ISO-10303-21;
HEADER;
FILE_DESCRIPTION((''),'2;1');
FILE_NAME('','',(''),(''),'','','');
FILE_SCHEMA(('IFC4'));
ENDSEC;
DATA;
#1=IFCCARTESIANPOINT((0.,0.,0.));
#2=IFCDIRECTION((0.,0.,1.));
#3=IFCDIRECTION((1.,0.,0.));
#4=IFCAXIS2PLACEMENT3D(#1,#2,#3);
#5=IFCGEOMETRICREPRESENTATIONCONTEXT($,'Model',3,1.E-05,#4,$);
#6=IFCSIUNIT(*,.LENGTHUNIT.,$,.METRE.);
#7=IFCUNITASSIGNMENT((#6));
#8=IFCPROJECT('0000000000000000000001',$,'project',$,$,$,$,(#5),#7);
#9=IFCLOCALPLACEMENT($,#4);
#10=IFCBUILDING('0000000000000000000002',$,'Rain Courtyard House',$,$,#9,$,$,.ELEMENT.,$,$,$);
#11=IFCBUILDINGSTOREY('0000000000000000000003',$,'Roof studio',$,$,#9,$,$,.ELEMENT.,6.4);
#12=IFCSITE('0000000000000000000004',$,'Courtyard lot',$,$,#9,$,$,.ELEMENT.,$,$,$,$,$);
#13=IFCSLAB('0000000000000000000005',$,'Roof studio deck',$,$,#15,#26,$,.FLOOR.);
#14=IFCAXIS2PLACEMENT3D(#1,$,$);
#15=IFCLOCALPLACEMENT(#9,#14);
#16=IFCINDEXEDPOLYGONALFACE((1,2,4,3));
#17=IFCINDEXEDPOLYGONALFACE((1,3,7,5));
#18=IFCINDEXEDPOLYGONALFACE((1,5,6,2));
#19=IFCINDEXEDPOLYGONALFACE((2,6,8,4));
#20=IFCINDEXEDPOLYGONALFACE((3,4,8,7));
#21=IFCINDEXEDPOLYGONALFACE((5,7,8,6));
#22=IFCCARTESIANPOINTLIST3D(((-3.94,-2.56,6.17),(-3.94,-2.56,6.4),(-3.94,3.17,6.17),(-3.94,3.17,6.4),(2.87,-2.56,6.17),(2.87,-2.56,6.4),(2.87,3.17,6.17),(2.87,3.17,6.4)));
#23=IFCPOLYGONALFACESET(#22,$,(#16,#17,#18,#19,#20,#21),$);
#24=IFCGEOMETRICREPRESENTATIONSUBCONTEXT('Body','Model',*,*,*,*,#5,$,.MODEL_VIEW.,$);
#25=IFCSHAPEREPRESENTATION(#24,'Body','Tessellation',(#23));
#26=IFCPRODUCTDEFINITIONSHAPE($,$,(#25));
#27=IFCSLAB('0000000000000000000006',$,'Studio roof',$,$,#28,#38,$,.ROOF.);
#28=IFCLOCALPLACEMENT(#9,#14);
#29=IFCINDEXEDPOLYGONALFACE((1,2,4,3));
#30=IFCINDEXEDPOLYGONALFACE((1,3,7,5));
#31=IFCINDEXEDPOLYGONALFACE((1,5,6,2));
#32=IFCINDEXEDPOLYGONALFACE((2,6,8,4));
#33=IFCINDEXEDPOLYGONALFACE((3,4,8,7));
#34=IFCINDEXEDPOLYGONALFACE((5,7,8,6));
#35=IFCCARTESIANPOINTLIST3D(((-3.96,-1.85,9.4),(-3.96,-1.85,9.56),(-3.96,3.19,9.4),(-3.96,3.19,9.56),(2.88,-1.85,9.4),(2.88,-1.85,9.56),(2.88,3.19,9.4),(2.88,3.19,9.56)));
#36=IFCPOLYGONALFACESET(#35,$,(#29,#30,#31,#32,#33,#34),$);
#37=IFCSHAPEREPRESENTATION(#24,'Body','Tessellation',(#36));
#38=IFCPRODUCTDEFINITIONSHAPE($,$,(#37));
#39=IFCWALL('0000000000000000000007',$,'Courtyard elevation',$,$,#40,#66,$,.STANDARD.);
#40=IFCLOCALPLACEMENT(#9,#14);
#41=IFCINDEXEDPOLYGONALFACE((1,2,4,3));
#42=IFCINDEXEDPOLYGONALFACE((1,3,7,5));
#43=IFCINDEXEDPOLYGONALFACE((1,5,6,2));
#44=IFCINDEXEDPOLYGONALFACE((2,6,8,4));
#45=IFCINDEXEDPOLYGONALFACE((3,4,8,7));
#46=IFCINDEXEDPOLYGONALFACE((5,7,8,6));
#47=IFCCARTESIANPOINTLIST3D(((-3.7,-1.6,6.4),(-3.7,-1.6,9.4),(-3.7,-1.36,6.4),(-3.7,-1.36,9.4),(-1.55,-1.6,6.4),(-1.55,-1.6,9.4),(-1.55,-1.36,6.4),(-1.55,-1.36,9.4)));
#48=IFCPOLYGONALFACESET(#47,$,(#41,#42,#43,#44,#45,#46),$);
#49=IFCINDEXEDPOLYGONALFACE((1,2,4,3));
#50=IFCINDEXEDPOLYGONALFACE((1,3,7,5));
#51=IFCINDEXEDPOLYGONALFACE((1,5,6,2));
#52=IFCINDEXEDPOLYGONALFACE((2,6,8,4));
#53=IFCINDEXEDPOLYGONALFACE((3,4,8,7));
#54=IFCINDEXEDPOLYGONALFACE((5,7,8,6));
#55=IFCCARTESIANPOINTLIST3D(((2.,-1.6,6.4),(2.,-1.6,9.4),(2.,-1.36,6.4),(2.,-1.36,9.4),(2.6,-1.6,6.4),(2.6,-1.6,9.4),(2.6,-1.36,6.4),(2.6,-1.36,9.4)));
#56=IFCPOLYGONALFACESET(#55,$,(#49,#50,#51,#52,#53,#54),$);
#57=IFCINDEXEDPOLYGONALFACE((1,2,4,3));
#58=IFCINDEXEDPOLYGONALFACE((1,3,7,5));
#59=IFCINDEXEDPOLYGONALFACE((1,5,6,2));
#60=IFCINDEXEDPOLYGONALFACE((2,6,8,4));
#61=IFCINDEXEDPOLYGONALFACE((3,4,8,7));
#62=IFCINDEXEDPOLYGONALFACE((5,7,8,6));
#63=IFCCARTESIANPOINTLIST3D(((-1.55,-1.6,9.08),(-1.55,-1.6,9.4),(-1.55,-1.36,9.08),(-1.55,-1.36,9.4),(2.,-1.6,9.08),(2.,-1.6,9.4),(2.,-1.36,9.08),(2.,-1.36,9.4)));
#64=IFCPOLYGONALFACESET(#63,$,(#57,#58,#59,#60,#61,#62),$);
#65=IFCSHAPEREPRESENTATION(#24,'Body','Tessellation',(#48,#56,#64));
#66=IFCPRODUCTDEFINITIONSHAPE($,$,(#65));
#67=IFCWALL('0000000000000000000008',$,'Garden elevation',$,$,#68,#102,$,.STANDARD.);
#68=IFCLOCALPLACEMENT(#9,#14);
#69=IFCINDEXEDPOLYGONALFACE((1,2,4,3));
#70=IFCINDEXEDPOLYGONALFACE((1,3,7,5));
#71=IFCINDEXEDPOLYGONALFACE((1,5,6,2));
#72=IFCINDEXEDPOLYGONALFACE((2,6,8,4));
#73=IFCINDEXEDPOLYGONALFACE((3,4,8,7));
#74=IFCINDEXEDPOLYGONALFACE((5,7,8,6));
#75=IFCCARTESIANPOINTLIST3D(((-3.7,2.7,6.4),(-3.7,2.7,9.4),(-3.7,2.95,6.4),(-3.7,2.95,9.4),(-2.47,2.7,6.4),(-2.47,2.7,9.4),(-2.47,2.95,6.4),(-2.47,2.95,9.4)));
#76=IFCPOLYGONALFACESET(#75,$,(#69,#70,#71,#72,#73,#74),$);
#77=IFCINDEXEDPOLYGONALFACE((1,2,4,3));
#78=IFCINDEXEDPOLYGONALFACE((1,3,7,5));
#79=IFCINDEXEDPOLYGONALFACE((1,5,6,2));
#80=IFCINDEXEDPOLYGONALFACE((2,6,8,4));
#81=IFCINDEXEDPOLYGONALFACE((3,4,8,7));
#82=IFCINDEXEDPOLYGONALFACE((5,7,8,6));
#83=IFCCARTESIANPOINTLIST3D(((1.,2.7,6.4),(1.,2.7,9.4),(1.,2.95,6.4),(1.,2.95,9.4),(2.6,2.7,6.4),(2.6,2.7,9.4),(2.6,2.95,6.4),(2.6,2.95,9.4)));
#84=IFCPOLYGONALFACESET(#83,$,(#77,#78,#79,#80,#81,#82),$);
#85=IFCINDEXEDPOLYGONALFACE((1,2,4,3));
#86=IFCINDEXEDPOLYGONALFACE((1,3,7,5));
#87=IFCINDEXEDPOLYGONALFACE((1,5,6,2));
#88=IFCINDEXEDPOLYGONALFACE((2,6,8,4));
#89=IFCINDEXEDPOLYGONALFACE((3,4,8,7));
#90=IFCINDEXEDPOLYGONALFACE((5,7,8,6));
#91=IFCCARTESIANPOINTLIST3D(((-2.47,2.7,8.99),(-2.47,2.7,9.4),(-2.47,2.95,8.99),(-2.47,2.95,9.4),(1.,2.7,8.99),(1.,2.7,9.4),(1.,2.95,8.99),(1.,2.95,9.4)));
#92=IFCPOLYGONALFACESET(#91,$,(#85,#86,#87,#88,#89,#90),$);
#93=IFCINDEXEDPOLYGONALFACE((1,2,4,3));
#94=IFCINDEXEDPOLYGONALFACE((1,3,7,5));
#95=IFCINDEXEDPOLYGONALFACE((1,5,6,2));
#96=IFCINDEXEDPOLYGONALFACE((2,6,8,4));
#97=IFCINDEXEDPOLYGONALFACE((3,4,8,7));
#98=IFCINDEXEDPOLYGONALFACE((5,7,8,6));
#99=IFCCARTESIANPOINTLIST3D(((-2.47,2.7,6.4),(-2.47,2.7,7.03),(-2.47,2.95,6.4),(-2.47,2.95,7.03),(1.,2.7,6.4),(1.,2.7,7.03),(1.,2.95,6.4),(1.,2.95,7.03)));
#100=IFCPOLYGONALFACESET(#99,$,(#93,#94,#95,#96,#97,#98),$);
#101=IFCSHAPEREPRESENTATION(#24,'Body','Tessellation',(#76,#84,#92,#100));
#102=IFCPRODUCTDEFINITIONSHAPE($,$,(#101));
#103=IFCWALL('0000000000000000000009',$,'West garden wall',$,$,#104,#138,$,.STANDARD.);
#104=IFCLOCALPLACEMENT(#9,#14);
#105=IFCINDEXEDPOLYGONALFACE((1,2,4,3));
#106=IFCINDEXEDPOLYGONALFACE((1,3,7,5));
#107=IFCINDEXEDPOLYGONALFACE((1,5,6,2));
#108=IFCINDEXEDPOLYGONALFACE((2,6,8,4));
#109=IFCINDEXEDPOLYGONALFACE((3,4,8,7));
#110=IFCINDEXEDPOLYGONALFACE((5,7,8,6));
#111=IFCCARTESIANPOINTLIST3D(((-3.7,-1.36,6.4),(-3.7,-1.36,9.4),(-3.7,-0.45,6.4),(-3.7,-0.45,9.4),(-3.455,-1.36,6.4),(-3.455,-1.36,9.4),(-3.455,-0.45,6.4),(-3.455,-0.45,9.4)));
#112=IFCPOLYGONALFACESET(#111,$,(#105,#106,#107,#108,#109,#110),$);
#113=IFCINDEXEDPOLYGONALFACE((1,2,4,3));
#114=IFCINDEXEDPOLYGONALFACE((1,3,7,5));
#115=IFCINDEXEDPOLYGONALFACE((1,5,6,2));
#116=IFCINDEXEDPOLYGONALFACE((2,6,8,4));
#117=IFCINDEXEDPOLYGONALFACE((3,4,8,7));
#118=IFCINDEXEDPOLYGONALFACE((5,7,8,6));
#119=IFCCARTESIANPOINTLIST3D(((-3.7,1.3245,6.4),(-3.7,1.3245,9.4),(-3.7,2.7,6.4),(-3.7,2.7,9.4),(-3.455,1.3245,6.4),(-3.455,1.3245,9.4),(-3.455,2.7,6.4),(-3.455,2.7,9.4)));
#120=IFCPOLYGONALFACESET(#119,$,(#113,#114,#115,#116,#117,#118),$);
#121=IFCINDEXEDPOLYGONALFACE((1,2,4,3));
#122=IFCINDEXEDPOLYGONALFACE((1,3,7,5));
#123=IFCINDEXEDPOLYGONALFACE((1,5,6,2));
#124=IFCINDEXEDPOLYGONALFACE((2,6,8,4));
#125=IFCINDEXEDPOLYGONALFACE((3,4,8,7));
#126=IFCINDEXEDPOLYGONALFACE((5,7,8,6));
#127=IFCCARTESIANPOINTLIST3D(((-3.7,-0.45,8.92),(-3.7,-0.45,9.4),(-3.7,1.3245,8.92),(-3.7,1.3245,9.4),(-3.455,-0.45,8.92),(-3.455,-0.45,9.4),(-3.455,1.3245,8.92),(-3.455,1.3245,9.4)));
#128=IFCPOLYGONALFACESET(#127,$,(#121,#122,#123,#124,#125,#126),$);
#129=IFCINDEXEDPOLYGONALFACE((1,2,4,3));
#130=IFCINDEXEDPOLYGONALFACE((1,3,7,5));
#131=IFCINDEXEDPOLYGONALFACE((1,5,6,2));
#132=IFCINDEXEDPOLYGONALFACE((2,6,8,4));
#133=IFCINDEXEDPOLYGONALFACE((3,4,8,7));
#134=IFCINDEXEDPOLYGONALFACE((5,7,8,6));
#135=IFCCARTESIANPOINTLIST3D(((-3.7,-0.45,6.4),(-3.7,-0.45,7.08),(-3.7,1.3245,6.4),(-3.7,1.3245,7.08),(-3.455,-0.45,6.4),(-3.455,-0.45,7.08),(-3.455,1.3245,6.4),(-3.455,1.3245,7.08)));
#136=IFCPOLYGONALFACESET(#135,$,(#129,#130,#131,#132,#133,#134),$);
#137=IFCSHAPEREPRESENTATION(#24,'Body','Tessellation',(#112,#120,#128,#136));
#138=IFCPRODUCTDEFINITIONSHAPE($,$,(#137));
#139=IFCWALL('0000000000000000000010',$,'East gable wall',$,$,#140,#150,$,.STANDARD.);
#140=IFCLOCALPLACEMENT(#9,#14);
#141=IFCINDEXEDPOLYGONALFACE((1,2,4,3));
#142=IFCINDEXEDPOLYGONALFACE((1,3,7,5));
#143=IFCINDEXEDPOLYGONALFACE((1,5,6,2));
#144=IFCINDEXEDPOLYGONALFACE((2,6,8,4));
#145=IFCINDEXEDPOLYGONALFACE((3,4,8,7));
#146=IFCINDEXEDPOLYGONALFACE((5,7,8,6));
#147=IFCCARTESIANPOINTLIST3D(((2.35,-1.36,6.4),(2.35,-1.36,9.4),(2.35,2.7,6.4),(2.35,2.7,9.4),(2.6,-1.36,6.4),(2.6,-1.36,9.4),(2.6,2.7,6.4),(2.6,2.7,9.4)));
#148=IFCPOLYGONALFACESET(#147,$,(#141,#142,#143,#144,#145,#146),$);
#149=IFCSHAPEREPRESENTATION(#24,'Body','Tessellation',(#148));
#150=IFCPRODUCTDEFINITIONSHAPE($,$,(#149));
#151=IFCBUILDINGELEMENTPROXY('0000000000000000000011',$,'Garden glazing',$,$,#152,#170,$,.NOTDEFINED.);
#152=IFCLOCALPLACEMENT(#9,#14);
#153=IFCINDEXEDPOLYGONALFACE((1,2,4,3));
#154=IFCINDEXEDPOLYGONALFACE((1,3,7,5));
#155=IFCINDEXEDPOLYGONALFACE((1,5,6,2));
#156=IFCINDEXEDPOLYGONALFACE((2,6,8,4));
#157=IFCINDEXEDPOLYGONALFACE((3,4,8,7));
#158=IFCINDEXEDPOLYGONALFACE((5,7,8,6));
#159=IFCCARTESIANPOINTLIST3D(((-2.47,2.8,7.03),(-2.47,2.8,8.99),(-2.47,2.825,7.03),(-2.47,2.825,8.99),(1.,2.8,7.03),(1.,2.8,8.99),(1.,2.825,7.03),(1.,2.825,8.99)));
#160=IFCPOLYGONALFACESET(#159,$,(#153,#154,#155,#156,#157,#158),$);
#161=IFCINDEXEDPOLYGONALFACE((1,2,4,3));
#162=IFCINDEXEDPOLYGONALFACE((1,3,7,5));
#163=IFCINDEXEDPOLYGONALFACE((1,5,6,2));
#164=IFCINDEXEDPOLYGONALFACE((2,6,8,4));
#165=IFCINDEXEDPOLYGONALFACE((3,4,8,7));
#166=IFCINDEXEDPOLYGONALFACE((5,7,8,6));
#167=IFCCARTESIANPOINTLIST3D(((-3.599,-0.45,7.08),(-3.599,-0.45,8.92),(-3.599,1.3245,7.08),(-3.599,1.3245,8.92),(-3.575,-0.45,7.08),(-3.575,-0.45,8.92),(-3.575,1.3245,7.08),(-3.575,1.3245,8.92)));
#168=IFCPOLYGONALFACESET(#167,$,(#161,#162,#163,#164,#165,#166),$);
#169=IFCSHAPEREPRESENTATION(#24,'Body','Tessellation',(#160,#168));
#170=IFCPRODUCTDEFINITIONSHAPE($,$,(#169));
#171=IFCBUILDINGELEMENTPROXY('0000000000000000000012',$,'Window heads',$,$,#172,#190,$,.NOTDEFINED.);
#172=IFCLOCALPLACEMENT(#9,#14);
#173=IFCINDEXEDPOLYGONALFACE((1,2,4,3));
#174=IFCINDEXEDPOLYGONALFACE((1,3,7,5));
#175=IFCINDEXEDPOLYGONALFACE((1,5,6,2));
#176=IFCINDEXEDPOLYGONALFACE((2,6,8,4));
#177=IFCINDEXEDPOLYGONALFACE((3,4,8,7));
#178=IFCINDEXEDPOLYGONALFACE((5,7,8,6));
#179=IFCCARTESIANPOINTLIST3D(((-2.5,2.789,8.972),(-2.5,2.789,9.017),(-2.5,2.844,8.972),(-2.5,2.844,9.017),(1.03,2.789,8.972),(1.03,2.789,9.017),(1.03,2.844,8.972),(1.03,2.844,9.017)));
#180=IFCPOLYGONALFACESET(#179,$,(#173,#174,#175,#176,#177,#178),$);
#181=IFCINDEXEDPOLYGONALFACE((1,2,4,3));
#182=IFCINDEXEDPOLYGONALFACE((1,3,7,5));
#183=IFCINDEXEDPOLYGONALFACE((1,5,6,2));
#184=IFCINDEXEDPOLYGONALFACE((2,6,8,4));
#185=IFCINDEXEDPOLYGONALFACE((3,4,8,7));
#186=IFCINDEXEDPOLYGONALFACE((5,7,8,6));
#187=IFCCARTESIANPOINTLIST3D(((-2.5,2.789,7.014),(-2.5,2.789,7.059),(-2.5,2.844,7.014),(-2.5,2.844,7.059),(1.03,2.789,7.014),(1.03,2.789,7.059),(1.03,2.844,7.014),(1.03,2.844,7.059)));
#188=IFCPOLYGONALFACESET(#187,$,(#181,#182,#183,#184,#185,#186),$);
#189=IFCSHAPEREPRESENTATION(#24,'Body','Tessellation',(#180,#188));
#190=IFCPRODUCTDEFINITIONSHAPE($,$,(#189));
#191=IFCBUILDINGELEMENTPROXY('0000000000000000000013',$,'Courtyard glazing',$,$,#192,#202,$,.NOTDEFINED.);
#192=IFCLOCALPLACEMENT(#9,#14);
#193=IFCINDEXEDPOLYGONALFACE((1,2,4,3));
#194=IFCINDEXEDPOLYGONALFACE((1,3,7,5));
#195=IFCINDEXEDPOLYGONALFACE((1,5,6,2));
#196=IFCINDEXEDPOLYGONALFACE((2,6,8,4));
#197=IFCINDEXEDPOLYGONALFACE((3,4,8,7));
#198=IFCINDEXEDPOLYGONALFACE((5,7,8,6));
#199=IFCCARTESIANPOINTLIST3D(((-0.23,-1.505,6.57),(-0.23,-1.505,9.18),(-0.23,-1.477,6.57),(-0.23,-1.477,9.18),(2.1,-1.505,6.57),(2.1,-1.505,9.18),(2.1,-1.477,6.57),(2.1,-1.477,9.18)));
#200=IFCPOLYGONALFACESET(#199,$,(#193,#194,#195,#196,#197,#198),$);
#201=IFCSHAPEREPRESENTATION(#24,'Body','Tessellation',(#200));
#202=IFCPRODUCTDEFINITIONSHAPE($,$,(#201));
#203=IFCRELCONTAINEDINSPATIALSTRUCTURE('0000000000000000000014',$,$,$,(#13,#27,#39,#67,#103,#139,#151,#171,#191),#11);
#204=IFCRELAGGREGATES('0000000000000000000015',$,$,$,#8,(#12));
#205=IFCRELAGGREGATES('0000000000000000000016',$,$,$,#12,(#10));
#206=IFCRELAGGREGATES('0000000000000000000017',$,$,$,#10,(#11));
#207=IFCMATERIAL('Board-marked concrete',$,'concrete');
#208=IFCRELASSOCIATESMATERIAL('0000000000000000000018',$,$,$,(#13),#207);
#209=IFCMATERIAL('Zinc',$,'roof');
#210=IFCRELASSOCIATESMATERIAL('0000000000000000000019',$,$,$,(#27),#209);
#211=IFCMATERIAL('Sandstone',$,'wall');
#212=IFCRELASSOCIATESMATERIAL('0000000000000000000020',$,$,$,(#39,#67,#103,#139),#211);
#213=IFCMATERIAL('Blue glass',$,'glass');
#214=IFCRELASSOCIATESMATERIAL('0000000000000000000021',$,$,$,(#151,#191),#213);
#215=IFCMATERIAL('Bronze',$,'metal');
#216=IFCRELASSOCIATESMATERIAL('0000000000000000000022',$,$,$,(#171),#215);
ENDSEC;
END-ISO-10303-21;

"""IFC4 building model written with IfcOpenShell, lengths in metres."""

from ifc_helpers import new_model, si_unit, frame, origin_with_axes, origin_2d, place, context, subcontext, project, spatial, rectangle, extrude, material, element, save


model = new_model("IFC4")

# Units and contexts
model_context = context("Model", 3, precision=1e-05, world=origin_with_axes())
body_context = subcontext(model_context, "Body", "Model", "MODEL_VIEW")
ifc_project = project(units=[si_unit("LENGTHUNIT", "METRE")], contexts=[model_context])

# Site, building, storey
placement = place(None, origin_with_axes())
site = spatial("IfcSite", under=ifc_project, at=placement, Name="Courtyard lot", CompositionType="ELEMENT")
building = spatial("IfcBuilding", under=site, at=placement, Name="Rain Courtyard House", CompositionType="ELEMENT")
storey = spatial("IfcBuildingStorey", under=building, at=placement, Name="Roof studio", CompositionType="ELEMENT", Elevation=6.4)

# Slabs
ifc_material_1 = material(Name="Board-marked concrete", Category="concrete")
element("IfcSlab", 1, at=placement, inside=storey, material=ifc_material_1, Name="Roof studio deck", PredefinedType="FLOOR", context=body_context, shape_type="SweptSolid", body=[
    extrude(rectangle(XDim=6.81, YDim=5.73, at=origin_2d()), frame((-0.535, 0.305, 6.17), z_axis=(0.0, 0.0, 1.0), x_axis=(1.0, 0.0, 0.0)), (0.0, 0.0, 1.0), 0.23),
])
ifc_material_2 = material(Name="Zinc", Category="roof")
element("IfcSlab", 2, at=placement, inside=storey, material=ifc_material_2, Name="Studio roof", PredefinedType="ROOF", context=body_context, shape_type="SweptSolid", body=[
    extrude(rectangle(XDim=6.84, YDim=5.04, at=origin_2d()), frame((-0.54, 0.67, 9.4), z_axis=(0.0, 0.0, 1.0), x_axis=(1.0, 0.0, 0.0)), (0.0, 0.0, 1.0), 0.16),
])

# Walls
ifc_material_3 = material(Name="Sandstone", Category="wall")
element("IfcWall", 3, at=placement, inside=storey, material=ifc_material_3, Name="Courtyard elevation", PredefinedType="STANDARD", context=body_context, shape_type="SweptSolid", body=[
    extrude(rectangle(XDim=2.15, YDim=0.24, at=origin_2d()), frame((-2.625, -1.48, 6.4), z_axis=(0.0, 0.0, 1.0), x_axis=(1.0, 0.0, 0.0)), (0.0, 0.0, 1.0), 3.0),
    extrude(rectangle(XDim=0.6, YDim=0.24, at=origin_2d()), frame((2.3, -1.48, 6.4), z_axis=(0.0, 0.0, 1.0), x_axis=(1.0, 0.0, 0.0)), (0.0, 0.0, 1.0), 3.0),
    extrude(rectangle(XDim=3.55, YDim=0.24, at=origin_2d()), frame((0.225, -1.48, 9.08), z_axis=(0.0, 0.0, 1.0), x_axis=(1.0, 0.0, 0.0)), (0.0, 0.0, 1.0), 0.32),
])
element("IfcWall", 4, at=placement, inside=storey, material=ifc_material_3, Name="Garden elevation", PredefinedType="STANDARD", context=body_context, shape_type="SweptSolid", body=[
    extrude(rectangle(XDim=1.23, YDim=0.25, at=origin_2d()), frame((-3.085, 2.825, 6.4), z_axis=(0.0, 0.0, 1.0), x_axis=(1.0, 0.0, 0.0)), (0.0, 0.0, 1.0), 3.0),
    extrude(rectangle(XDim=1.6, YDim=0.25, at=origin_2d()), frame((1.8, 2.825, 6.4), z_axis=(0.0, 0.0, 1.0), x_axis=(1.0, 0.0, 0.0)), (0.0, 0.0, 1.0), 3.0),
    extrude(rectangle(XDim=3.47, YDim=0.25, at=origin_2d()), frame((-0.735, 2.825, 8.99), z_axis=(0.0, 0.0, 1.0), x_axis=(1.0, 0.0, 0.0)), (0.0, 0.0, 1.0), 0.41),
    extrude(rectangle(XDim=3.47, YDim=0.25, at=origin_2d()), frame((-0.735, 2.825, 6.4), z_axis=(0.0, 0.0, 1.0), x_axis=(1.0, 0.0, 0.0)), (0.0, 0.0, 1.0), 0.63),
])
element("IfcWall", 5, at=placement, inside=storey, material=ifc_material_3, Name="West garden wall", PredefinedType="STANDARD", context=body_context, shape_type="SweptSolid", body=[
    extrude(rectangle(XDim=0.245, YDim=0.91, at=origin_2d()), frame((-3.5775, -0.905, 6.4), z_axis=(0.0, 0.0, 1.0), x_axis=(1.0, 0.0, 0.0)), (0.0, 0.0, 1.0), 3.0),
    extrude(rectangle(XDim=0.245, YDim=1.3755, at=origin_2d()), frame((-3.5775, 2.0122, 6.4), z_axis=(0.0, 0.0, 1.0), x_axis=(1.0, 0.0, 0.0)), (0.0, 0.0, 1.0), 3.0),
    extrude(rectangle(XDim=0.245, YDim=1.7745, at=origin_2d()), frame((-3.5775, 0.4373, 8.92), z_axis=(0.0, 0.0, 1.0), x_axis=(1.0, 0.0, 0.0)), (0.0, 0.0, 1.0), 0.48),
    extrude(rectangle(XDim=0.245, YDim=1.7745, at=origin_2d()), frame((-3.5775, 0.4373, 6.4), z_axis=(0.0, 0.0, 1.0), x_axis=(1.0, 0.0, 0.0)), (0.0, 0.0, 1.0), 0.68),
])
element("IfcWall", 6, at=placement, inside=storey, material=ifc_material_3, Name="East gable wall", PredefinedType="STANDARD", context=body_context, shape_type="SweptSolid", body=[
    extrude(rectangle(XDim=0.25, YDim=4.06, at=origin_2d()), frame((2.475, 0.67, 6.4), z_axis=(0.0, 0.0, 1.0), x_axis=(1.0, 0.0, 0.0)), (0.0, 0.0, 1.0), 3.0),
])

# Building element proxies
ifc_material_4 = material(Name="Blue glass", Category="glass")
element("IfcBuildingElementProxy", 7, at=placement, inside=storey, material=ifc_material_4, Name="Garden glazing", PredefinedType="NOTDEFINED", context=body_context, shape_type="SweptSolid", body=[
    extrude(rectangle(XDim=3.47, YDim=0.025, at=origin_2d()), frame((-0.735, 2.8125, 7.03), z_axis=(0.0, 0.0, 1.0), x_axis=(1.0, 0.0, 0.0)), (0.0, 0.0, 1.0), 1.96),
    extrude(rectangle(XDim=0.024, YDim=1.7745, at=origin_2d()), frame((-3.587, 0.4373, 7.08), z_axis=(0.0, 0.0, 1.0), x_axis=(1.0, 0.0, 0.0)), (0.0, 0.0, 1.0), 1.84),
])
ifc_material_5 = material(Name="Bronze", Category="metal")
element("IfcBuildingElementProxy", 8, at=placement, inside=storey, material=ifc_material_5, Name="Window heads", PredefinedType="NOTDEFINED", context=body_context, shape_type="SweptSolid", body=[
    extrude(rectangle(XDim=3.53, YDim=0.055, at=origin_2d()), frame((-0.735, 2.8165, 8.972), z_axis=(0.0, 0.0, 1.0), x_axis=(1.0, 0.0, 0.0)), (0.0, 0.0, 1.0), 0.045),
    extrude(rectangle(XDim=3.53, YDim=0.055, at=origin_2d()), frame((-0.735, 2.8165, 7.014), z_axis=(0.0, 0.0, 1.0), x_axis=(1.0, 0.0, 0.0)), (0.0, 0.0, 1.0), 0.045),
])
element("IfcBuildingElementProxy", 9, at=placement, inside=storey, material=ifc_material_4, Name="Courtyard glazing", PredefinedType="NOTDEFINED", context=body_context, shape_type="SweptSolid", body=[
    extrude(rectangle(XDim=2.33, YDim=0.028, at=origin_2d()), frame((0.935, -1.491, 6.57), z_axis=(0.0, 0.0, 1.0), x_axis=(1.0, 0.0, 0.0)), (0.0, 0.0, 1.0), 2.61),
])

save(model, "model.ifc")
